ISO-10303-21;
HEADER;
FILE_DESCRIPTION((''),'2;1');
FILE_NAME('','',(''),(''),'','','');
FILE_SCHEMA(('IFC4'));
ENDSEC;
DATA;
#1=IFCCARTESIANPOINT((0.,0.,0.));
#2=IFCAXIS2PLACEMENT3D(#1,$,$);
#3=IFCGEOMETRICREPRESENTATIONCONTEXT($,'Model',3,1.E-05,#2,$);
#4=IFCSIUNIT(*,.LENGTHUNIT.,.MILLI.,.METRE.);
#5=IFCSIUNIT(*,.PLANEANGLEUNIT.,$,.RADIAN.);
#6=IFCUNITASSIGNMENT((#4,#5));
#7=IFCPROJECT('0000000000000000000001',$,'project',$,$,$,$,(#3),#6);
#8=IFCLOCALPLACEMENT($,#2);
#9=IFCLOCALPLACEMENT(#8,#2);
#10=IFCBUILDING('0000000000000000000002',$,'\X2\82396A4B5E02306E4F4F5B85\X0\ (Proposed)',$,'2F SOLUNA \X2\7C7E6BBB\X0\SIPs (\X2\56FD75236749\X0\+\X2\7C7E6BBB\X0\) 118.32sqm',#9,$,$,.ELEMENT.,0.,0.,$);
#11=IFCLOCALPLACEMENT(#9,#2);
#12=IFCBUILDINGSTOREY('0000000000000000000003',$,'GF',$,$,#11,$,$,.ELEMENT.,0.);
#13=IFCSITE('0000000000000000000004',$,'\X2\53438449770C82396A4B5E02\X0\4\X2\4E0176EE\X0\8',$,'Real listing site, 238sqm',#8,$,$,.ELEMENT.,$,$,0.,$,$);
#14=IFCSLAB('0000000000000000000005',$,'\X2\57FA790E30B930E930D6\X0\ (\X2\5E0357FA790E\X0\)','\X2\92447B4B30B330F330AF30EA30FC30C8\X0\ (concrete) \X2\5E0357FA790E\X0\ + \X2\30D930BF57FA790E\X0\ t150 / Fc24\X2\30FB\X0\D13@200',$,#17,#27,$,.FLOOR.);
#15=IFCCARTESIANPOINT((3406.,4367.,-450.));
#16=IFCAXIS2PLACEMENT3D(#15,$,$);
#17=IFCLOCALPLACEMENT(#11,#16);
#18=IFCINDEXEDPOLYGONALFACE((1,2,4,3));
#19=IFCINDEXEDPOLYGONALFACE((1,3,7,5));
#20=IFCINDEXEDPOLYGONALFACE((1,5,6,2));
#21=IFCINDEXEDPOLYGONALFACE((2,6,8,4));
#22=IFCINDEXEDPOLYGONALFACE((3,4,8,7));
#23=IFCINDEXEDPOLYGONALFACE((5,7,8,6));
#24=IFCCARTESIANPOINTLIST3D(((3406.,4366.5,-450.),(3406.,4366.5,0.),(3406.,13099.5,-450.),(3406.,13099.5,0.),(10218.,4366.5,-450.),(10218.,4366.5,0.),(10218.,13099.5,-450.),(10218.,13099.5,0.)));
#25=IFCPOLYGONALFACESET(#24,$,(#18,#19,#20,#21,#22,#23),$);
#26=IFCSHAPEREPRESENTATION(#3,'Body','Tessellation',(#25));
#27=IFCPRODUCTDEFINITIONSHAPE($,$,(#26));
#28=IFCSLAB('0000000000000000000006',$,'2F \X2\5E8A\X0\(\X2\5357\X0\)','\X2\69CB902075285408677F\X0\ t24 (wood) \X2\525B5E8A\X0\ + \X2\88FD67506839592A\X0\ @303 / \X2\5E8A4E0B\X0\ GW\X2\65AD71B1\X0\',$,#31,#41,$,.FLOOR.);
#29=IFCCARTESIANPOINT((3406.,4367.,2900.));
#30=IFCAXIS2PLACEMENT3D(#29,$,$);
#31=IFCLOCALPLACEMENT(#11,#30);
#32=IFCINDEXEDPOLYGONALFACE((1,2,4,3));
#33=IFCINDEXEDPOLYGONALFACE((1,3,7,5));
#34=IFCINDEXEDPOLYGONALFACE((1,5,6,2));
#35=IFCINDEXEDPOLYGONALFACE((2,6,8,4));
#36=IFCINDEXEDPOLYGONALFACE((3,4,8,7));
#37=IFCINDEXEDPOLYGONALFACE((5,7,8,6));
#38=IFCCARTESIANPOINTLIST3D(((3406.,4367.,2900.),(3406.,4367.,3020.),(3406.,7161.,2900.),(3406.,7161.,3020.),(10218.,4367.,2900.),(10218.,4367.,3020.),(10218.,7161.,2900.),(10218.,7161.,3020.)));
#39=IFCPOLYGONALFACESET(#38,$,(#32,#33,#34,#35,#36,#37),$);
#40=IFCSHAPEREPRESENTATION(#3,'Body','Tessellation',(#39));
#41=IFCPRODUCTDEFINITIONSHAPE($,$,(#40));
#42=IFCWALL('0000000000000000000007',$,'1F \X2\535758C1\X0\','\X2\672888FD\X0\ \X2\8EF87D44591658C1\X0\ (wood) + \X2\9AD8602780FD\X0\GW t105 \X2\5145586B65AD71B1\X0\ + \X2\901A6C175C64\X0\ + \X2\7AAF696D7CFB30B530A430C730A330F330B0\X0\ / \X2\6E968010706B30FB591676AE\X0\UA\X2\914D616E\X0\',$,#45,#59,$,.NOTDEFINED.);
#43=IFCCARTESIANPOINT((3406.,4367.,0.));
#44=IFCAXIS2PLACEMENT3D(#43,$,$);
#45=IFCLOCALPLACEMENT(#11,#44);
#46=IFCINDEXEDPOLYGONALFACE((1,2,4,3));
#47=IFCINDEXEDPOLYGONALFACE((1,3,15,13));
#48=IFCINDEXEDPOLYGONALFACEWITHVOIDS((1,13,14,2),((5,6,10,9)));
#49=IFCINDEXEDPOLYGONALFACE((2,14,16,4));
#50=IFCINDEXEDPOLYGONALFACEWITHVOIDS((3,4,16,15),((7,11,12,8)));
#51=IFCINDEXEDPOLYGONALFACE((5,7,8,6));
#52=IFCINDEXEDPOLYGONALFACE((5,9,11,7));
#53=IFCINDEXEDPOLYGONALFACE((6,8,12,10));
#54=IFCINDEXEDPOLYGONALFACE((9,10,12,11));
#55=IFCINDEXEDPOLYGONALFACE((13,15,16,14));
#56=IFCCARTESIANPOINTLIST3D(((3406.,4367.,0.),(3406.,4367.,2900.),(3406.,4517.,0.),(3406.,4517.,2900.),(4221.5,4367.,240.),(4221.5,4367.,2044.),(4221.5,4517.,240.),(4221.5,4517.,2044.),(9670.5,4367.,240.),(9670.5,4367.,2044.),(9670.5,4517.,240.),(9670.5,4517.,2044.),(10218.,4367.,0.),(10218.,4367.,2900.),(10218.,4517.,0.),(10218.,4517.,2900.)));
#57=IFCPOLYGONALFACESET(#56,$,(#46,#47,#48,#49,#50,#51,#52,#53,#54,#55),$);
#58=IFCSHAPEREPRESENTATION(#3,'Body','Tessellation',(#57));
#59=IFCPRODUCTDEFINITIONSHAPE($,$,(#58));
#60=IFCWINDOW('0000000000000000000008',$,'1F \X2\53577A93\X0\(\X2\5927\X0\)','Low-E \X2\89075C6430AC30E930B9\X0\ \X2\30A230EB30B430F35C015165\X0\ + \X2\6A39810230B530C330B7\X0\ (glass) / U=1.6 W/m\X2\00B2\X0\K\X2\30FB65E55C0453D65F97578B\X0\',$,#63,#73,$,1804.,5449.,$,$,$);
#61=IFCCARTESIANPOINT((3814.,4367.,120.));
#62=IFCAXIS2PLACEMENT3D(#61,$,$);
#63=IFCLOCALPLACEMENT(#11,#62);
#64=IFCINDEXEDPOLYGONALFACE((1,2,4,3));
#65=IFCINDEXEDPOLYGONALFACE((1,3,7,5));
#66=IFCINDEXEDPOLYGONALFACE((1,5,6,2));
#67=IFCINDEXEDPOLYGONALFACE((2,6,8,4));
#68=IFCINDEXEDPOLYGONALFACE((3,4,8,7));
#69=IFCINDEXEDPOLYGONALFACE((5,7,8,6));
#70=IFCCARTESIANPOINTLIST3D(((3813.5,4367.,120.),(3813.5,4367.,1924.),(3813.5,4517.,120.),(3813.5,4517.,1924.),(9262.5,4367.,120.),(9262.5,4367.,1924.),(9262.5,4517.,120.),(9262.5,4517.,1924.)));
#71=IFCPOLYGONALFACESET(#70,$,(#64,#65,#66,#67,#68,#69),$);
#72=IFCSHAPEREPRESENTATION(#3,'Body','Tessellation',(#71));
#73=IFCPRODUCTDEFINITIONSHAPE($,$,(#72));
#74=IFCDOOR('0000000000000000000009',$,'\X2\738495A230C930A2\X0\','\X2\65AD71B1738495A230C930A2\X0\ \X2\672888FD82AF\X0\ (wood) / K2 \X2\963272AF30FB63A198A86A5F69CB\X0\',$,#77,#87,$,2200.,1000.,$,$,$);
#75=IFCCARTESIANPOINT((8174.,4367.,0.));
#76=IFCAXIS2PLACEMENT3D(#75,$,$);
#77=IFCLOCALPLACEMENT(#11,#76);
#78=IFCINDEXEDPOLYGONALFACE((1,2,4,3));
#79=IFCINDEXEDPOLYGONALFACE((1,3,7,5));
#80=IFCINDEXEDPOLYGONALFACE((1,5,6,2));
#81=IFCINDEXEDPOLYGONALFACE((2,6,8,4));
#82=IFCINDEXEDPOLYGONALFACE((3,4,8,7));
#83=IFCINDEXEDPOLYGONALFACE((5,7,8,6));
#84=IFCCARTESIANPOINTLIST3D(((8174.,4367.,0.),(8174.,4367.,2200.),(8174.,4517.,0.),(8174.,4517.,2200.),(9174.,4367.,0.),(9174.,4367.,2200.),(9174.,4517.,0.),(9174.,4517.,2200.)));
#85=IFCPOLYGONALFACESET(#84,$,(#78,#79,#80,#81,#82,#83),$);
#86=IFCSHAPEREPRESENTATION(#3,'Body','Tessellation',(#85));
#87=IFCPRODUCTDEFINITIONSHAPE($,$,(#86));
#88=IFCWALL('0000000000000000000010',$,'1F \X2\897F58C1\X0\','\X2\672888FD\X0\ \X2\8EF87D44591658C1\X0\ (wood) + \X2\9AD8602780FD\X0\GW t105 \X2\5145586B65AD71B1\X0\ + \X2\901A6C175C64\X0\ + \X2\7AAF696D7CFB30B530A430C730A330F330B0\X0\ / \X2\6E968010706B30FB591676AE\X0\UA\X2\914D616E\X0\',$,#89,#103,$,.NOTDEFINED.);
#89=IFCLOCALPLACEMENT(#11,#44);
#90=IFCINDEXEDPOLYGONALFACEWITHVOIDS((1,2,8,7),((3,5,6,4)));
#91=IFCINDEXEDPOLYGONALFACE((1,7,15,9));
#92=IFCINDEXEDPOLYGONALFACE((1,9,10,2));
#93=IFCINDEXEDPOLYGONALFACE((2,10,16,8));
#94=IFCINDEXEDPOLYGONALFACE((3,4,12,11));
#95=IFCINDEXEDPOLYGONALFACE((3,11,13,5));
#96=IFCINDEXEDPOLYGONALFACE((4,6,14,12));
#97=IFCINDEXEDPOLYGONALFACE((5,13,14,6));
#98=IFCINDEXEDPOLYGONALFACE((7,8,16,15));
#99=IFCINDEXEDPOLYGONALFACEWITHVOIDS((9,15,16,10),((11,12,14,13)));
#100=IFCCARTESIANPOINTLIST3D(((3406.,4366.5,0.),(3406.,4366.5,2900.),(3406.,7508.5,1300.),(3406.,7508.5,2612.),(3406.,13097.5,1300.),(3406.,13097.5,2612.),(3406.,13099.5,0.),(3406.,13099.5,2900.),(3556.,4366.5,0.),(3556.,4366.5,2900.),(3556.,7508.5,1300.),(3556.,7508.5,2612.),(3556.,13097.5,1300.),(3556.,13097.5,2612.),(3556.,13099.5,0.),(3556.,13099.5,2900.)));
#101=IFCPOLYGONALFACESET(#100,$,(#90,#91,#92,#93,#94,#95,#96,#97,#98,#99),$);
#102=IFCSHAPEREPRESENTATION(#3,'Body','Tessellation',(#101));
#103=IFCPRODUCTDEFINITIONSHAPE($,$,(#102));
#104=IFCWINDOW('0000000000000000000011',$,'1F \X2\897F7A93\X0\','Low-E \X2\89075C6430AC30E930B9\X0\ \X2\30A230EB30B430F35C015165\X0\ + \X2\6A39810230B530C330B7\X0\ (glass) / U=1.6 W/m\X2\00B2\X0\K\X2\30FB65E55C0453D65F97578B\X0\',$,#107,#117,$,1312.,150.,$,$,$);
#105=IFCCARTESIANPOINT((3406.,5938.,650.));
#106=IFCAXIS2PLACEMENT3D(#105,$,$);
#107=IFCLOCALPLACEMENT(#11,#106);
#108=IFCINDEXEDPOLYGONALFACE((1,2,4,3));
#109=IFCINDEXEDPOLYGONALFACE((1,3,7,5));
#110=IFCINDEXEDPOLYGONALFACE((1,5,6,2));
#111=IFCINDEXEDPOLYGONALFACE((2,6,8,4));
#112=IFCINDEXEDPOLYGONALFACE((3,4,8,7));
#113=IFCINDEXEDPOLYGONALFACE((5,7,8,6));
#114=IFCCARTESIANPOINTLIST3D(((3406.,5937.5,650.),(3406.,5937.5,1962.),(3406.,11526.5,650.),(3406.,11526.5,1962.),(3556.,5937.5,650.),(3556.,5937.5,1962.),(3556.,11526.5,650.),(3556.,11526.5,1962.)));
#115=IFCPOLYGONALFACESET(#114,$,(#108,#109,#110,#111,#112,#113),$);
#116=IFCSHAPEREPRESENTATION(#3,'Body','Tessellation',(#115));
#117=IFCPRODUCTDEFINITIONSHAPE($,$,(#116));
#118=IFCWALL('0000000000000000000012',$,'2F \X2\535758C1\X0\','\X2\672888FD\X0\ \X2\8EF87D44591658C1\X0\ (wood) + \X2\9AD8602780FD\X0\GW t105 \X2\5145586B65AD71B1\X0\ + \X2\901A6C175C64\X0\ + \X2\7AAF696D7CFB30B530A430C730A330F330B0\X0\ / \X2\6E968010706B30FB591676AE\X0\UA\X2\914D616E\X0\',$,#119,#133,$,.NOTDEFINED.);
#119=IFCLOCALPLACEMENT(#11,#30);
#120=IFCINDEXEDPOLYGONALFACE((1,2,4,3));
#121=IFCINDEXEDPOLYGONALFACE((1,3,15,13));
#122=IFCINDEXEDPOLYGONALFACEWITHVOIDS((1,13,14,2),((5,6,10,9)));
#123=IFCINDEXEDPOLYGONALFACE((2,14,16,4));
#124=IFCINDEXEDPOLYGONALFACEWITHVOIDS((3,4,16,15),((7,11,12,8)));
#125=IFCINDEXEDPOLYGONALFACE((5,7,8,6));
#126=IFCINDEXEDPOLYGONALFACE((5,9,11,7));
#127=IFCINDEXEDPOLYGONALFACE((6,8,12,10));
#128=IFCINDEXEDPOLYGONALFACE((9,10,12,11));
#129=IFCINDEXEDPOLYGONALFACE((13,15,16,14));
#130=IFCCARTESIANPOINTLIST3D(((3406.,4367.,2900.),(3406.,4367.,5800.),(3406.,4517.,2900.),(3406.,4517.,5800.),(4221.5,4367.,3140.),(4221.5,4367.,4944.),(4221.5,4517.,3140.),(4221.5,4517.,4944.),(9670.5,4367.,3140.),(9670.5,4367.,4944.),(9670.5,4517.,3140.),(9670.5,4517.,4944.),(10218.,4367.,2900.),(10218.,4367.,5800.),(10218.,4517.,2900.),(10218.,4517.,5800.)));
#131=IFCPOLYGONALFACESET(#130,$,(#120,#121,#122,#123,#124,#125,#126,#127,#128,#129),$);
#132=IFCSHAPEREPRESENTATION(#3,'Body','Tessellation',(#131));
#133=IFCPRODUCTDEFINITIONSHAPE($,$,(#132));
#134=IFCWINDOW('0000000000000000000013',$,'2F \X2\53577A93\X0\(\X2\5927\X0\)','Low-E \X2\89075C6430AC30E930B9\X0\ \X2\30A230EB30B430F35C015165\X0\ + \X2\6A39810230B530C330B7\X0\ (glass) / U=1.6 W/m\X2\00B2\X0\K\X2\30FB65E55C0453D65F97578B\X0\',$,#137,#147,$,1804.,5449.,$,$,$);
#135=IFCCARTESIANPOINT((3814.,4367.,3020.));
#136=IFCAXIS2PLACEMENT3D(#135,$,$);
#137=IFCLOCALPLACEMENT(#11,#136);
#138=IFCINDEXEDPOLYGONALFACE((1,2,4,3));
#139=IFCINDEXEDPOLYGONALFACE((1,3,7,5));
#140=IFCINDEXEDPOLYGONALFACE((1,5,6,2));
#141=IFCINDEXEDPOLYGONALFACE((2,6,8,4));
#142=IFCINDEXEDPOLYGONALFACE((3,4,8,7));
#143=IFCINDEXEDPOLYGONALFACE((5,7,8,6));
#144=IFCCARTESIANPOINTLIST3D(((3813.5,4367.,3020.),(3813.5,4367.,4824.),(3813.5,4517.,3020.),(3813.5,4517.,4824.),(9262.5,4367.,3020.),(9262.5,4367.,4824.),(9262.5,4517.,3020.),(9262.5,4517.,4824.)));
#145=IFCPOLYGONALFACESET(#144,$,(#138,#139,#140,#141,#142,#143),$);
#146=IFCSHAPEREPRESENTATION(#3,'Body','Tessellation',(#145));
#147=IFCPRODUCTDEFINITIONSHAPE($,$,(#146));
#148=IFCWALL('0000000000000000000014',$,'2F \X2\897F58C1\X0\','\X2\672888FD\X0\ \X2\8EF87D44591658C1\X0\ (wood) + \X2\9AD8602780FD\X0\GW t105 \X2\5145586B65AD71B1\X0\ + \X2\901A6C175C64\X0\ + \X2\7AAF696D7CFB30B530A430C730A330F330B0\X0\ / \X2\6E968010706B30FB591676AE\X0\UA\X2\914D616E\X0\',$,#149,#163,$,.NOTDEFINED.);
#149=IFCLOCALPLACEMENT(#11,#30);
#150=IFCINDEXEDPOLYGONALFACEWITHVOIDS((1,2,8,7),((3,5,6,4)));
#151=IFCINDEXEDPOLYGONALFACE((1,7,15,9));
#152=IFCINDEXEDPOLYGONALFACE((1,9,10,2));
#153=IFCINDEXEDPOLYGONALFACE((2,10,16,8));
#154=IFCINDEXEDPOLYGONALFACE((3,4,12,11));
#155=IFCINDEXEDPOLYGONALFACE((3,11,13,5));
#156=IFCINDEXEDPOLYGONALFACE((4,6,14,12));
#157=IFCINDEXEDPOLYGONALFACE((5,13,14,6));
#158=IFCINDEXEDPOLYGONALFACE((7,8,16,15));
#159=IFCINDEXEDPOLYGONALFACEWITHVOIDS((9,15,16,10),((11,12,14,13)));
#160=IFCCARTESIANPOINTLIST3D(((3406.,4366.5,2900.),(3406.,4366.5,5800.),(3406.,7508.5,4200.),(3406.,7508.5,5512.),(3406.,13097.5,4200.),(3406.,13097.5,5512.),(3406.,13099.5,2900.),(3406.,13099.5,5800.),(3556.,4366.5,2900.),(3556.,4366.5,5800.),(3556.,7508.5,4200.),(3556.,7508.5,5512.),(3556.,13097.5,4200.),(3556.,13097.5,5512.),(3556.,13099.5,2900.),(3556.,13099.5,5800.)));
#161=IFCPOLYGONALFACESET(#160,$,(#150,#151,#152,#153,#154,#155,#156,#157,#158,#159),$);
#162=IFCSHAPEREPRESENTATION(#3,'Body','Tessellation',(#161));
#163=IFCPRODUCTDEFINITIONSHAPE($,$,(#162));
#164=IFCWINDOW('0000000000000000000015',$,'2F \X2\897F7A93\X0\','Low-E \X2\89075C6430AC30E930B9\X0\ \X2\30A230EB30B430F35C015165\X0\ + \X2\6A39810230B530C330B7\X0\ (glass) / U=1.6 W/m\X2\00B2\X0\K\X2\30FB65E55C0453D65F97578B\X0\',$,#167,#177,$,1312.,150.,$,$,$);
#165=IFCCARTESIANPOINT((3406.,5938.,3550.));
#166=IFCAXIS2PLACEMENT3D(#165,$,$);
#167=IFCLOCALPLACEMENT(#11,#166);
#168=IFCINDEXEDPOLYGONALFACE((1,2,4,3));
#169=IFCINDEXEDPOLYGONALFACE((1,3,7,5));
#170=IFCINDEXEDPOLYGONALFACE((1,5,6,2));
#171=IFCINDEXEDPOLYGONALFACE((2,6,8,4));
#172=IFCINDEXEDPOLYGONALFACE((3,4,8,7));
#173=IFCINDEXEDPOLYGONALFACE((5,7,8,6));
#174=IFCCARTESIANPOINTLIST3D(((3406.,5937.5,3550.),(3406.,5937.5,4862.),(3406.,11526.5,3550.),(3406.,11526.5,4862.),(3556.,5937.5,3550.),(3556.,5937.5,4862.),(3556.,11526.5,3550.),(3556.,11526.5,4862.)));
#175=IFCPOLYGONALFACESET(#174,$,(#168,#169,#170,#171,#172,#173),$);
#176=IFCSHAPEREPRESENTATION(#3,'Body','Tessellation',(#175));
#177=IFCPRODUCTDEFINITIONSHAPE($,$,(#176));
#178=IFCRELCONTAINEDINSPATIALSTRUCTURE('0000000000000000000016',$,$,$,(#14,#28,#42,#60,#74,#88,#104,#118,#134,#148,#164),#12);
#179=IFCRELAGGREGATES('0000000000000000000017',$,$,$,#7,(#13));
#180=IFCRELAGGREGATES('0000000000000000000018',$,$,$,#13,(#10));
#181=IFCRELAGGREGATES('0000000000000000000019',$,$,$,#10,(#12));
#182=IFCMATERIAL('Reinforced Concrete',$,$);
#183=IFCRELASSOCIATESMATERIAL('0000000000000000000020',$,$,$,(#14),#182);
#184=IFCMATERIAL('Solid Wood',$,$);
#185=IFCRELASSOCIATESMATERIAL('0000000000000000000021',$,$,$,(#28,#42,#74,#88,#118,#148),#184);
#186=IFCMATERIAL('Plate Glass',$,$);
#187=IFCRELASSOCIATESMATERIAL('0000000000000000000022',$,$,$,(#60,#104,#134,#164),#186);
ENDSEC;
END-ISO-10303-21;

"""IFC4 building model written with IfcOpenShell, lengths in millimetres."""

from ifc_helpers import new_model, si_unit, frame, frame_2d, origin, place, context, project, spatial, rectangle, extrude, material, element, fill, save


model = new_model("IFC4")

# Units and contexts
model_context = context("Model", 3, precision=1e-05, world=origin())
ifc_project = project(units=[si_unit("LENGTHUNIT", "METRE", prefix="MILLI"), si_unit("PLANEANGLEUNIT", "RADIAN")], contexts=[model_context])

# Site, building, storey
site_placement = place(None, origin())
site = spatial("IfcSite", under=ifc_project, at=site_placement, Name="千葉県船橋市4丁目8", ObjectType="Real listing site, 238sqm", CompositionType="ELEMENT", RefElevation=0.0)
building_placement = place(site_placement, origin())
building = spatial("IfcBuilding", under=site, at=building_placement, Name="船橋市の住宅 (Proposed)", ObjectType="2F SOLUNA 籾殻SIPs (国産杉+籾殻) 118.32sqm", CompositionType="ELEMENT", ElevationOfRefHeight=0.0, ElevationOfTerrain=0.0)
storey_placement = place(building_placement, origin())
storey = spatial("IfcBuildingStorey", under=building, at=storey_placement, Name="GF", CompositionType="ELEMENT", Elevation=0.0)

# Slabs
ifc_material_1 = material(Name="Reinforced Concrete")
slab_1_placement = place(storey_placement, frame((3406.0, 4367.0, -450.0)))
element("IfcSlab", 1, at=slab_1_placement, inside=storey, material=ifc_material_1, Name="基礎スラブ (布基礎)", Description="鉄筋コンクリート (concrete) 布基礎 + ベタ基礎 t150 / Fc24・D13@200", PredefinedType="FLOOR", context=model_context, shape_type="SweptSolid", body=[
    extrude(rectangle(XDim=6812.0, YDim=8733.0, at=frame_2d((3406.0, 4366.0))), frame((3406.0, 4367.0, -450.0)), (0.0, 0.0, 1.0), 450.0),
])
ifc_material_2 = material(Name="Solid Wood")
slab_2_placement = place(storey_placement, frame((3406.0, 4367.0, 2900.0)))
element("IfcSlab", 2, at=slab_2_placement, inside=storey, material=ifc_material_2, Name="2F 床(南)", Description="構造用合板 t24 (wood) 剛床 + 製材根太 @303 / 床下 GW断熱", PredefinedType="FLOOR", context=model_context, shape_type="SweptSolid", body=[
    extrude(rectangle(XDim=6812.0, YDim=2794.0, at=frame_2d((3406.0, 1397.0))), frame((3406.0, 4367.0, 2900.0)), (0.0, 0.0, 1.0), 120.0),
])

# Wall, openings, window, door
wall_1_placement = place(storey_placement, frame((3406.0, 4367.0, 0.0)))
wall_1 = element("IfcWall", 3, at=wall_1_placement, inside=storey, material=ifc_material_2, Name="1F 南壁", Description="木製 軸組外壁 (wood) + 高性能GW t105 充填断熱 + 通気層 + 窯業系サイディング / 準耐火・外皮UA配慮", PredefinedType="NOTDEFINED", context=model_context, shape_type="SweptSolid", body=[
    extrude(rectangle(XDim=6812.0, YDim=150.0, at=frame_2d((3406.0, 75.0))), frame((3406.0, 4367.0, 0.0)), (0.0, 0.0, 1.0), 2900.0),
])
opening_1_placement = place(storey_placement, frame((3814.0, 4367.0, 120.0)))
opening_1 = element("IfcOpeningElement", 4, at=opening_1_placement, cuts=wall_1, PredefinedType="NOTDEFINED", context=model_context, shape_type="SweptSolid", body=[
    extrude(rectangle(XDim=5449.0, YDim=150.0, at=frame_2d((2724.0, 75.0))), frame((3814.0, 4367.0, 120.0)), (0.0, 0.0, 1.0), 1804.0),
])
opening_2_placement = place(storey_placement, frame((8174.0, 4367.0, 0.0)))
opening_2 = element("IfcOpeningElement", 5, at=opening_2_placement, cuts=wall_1, PredefinedType="NOTDEFINED", context=model_context, shape_type="SweptSolid", body=[
    extrude(rectangle(XDim=1000.0, YDim=150.0, at=frame_2d((500.0, 75.0))), frame((8174.0, 4367.0, 0.0)), (0.0, 0.0, 1.0), 2200.0),
])
ifc_material_3 = material(Name="Plate Glass")
window_1_placement = place(storey_placement, frame((3814.0, 4367.0, 120.0)))
window_1 = element("IfcWindow", 6, at=window_1_placement, inside=storey, material=ifc_material_3, Name="1F 南窓(大)", Description="Low-E 複層ガラス アルゴン封入 + 樹脂サッシ (glass) / U=1.6 W/m²K・日射取得型", OverallHeight=1804.0, OverallWidth=5449.0, context=model_context, shape_type="SweptSolid", body=[
    extrude(rectangle(XDim=5449.0, YDim=150.0, at=frame_2d((2724.0, 75.0))), frame((3814.0, 4367.0, 120.0)), (0.0, 0.0, 1.0), 1804.0),
])
fill(opening_1, window_1)
door_placement = place(storey_placement, frame((8174.0, 4367.0, 0.0)))
door = element("IfcDoor", 7, at=door_placement, inside=storey, material=ifc_material_2, Name="玄関ドア", Description="断熱玄関ドア 木製芯 (wood) / K2 防犯・採風機構", OverallHeight=2200.0, OverallWidth=1000.0, context=model_context, shape_type="SweptSolid", body=[
    extrude(rectangle(XDim=1000.0, YDim=150.0, at=frame_2d((500.0, 75.0))), frame((8174.0, 4367.0, 0.0)), (0.0, 0.0, 1.0), 2200.0),
])
fill(opening_2, door)

# Walls, openings, windows
wall_2_placement = place(storey_placement, frame((3406.0, 4367.0, 0.0)))
wall_2 = element("IfcWall", 8, at=wall_2_placement, inside=storey, material=ifc_material_2, Name="1F 西壁", Description="木製 軸組外壁 (wood) + 高性能GW t105 充填断熱 + 通気層 + 窯業系サイディング / 準耐火・外皮UA配慮", PredefinedType="NOTDEFINED", context=model_context, shape_type="SweptSolid", body=[
    extrude(rectangle(XDim=150.0, YDim=8733.0, at=frame_2d((75.0, 4366.0))), frame((3406.0, 4367.0, 0.0)), (0.0, 0.0, 1.0), 2900.0),
])
opening_3_placement = place(storey_placement, frame((3406.0, 5938.0, 650.0)))
opening_3 = element("IfcOpeningElement", 9, at=opening_3_placement, cuts=wall_2, PredefinedType="NOTDEFINED", context=model_context, shape_type="SweptSolid", body=[
    extrude(rectangle(XDim=150.0, YDim=5589.0, at=frame_2d((75.0, 2794.0))), frame((3406.0, 5938.0, 650.0)), (0.0, 0.0, 1.0), 1312.0),
])
window_2_placement = place(storey_placement, frame((3406.0, 5938.0, 650.0)))
window_2 = element("IfcWindow", 10, at=window_2_placement, inside=storey, material=ifc_material_3, Name="1F 西窓", Description="Low-E 複層ガラス アルゴン封入 + 樹脂サッシ (glass) / U=1.6 W/m²K・日射取得型", OverallHeight=1312.0, OverallWidth=150.0, context=model_context, shape_type="SweptSolid", body=[
    extrude(rectangle(XDim=150.0, YDim=5589.0, at=frame_2d((75.0, 2794.0))), frame((3406.0, 5938.0, 650.0)), (0.0, 0.0, 1.0), 1312.0),
])
fill(opening_3, window_2)
wall_3_placement = place(storey_placement, frame((3406.0, 4367.0, 2900.0)))
wall_3 = element("IfcWall", 11, at=wall_3_placement, inside=storey, material=ifc_material_2, Name="2F 南壁", Description="木製 軸組外壁 (wood) + 高性能GW t105 充填断熱 + 通気層 + 窯業系サイディング / 準耐火・外皮UA配慮", PredefinedType="NOTDEFINED", context=model_context, shape_type="SweptSolid", body=[
    extrude(rectangle(XDim=6812.0, YDim=150.0, at=frame_2d((3406.0, 75.0))), frame((3406.0, 4367.0, 2900.0)), (0.0, 0.0, 1.0), 2900.0),
])
opening_4_placement = place(storey_placement, frame((3814.0, 4367.0, 3020.0)))
opening_4 = element("IfcOpeningElement", 12, at=opening_4_placement, cuts=wall_3, PredefinedType="NOTDEFINED", context=model_context, shape_type="SweptSolid", body=[
    extrude(rectangle(XDim=5449.0, YDim=150.0, at=frame_2d((2724.0, 75.0))), frame((3814.0, 4367.0, 3020.0)), (0.0, 0.0, 1.0), 1804.0),
])
window_3_placement = place(storey_placement, frame((3814.0, 4367.0, 3020.0)))
window_3 = element("IfcWindow", 13, at=window_3_placement, inside=storey, material=ifc_material_3, Name="2F 南窓(大)", Description="Low-E 複層ガラス アルゴン封入 + 樹脂サッシ (glass) / U=1.6 W/m²K・日射取得型", OverallHeight=1804.0, OverallWidth=5449.0, context=model_context, shape_type="SweptSolid", body=[
    extrude(rectangle(XDim=5449.0, YDim=150.0, at=frame_2d((2724.0, 75.0))), frame((3814.0, 4367.0, 3020.0)), (0.0, 0.0, 1.0), 1804.0),
])
fill(opening_4, window_3)
wall_4_placement = place(storey_placement, frame((3406.0, 4367.0, 2900.0)))
wall_4 = element("IfcWall", 14, at=wall_4_placement, inside=storey, material=ifc_material_2, Name="2F 西壁", Description="木製 軸組外壁 (wood) + 高性能GW t105 充填断熱 + 通気層 + 窯業系サイディング / 準耐火・外皮UA配慮", PredefinedType="NOTDEFINED", context=model_context, shape_type="SweptSolid", body=[
    extrude(rectangle(XDim=150.0, YDim=8733.0, at=frame_2d((75.0, 4366.0))), frame((3406.0, 4367.0, 2900.0)), (0.0, 0.0, 1.0), 2900.0),
])
opening_5_placement = place(storey_placement, frame((3406.0, 5938.0, 3550.0)))
opening_5 = element("IfcOpeningElement", 15, at=opening_5_placement, cuts=wall_4, PredefinedType="NOTDEFINED", context=model_context, shape_type="SweptSolid", body=[
    extrude(rectangle(XDim=150.0, YDim=5589.0, at=frame_2d((75.0, 2794.0))), frame((3406.0, 5938.0, 3550.0)), (0.0, 0.0, 1.0), 1312.0),
])
window_4_placement = place(storey_placement, frame((3406.0, 5938.0, 3550.0)))
window_4 = element("IfcWindow", 16, at=window_4_placement, inside=storey, material=ifc_material_3, Name="2F 西窓", Description="Low-E 複層ガラス アルゴン封入 + 樹脂サッシ (glass) / U=1.6 W/m²K・日射取得型", OverallHeight=1312.0, OverallWidth=150.0, context=model_context, shape_type="SweptSolid", body=[
    extrude(rectangle(XDim=150.0, YDim=5589.0, at=frame_2d((75.0, 2794.0))), frame((3406.0, 5938.0, 3550.0)), (0.0, 0.0, 1.0), 1312.0),
])
fill(opening_5, window_4)

save(model, "model.ifc")
